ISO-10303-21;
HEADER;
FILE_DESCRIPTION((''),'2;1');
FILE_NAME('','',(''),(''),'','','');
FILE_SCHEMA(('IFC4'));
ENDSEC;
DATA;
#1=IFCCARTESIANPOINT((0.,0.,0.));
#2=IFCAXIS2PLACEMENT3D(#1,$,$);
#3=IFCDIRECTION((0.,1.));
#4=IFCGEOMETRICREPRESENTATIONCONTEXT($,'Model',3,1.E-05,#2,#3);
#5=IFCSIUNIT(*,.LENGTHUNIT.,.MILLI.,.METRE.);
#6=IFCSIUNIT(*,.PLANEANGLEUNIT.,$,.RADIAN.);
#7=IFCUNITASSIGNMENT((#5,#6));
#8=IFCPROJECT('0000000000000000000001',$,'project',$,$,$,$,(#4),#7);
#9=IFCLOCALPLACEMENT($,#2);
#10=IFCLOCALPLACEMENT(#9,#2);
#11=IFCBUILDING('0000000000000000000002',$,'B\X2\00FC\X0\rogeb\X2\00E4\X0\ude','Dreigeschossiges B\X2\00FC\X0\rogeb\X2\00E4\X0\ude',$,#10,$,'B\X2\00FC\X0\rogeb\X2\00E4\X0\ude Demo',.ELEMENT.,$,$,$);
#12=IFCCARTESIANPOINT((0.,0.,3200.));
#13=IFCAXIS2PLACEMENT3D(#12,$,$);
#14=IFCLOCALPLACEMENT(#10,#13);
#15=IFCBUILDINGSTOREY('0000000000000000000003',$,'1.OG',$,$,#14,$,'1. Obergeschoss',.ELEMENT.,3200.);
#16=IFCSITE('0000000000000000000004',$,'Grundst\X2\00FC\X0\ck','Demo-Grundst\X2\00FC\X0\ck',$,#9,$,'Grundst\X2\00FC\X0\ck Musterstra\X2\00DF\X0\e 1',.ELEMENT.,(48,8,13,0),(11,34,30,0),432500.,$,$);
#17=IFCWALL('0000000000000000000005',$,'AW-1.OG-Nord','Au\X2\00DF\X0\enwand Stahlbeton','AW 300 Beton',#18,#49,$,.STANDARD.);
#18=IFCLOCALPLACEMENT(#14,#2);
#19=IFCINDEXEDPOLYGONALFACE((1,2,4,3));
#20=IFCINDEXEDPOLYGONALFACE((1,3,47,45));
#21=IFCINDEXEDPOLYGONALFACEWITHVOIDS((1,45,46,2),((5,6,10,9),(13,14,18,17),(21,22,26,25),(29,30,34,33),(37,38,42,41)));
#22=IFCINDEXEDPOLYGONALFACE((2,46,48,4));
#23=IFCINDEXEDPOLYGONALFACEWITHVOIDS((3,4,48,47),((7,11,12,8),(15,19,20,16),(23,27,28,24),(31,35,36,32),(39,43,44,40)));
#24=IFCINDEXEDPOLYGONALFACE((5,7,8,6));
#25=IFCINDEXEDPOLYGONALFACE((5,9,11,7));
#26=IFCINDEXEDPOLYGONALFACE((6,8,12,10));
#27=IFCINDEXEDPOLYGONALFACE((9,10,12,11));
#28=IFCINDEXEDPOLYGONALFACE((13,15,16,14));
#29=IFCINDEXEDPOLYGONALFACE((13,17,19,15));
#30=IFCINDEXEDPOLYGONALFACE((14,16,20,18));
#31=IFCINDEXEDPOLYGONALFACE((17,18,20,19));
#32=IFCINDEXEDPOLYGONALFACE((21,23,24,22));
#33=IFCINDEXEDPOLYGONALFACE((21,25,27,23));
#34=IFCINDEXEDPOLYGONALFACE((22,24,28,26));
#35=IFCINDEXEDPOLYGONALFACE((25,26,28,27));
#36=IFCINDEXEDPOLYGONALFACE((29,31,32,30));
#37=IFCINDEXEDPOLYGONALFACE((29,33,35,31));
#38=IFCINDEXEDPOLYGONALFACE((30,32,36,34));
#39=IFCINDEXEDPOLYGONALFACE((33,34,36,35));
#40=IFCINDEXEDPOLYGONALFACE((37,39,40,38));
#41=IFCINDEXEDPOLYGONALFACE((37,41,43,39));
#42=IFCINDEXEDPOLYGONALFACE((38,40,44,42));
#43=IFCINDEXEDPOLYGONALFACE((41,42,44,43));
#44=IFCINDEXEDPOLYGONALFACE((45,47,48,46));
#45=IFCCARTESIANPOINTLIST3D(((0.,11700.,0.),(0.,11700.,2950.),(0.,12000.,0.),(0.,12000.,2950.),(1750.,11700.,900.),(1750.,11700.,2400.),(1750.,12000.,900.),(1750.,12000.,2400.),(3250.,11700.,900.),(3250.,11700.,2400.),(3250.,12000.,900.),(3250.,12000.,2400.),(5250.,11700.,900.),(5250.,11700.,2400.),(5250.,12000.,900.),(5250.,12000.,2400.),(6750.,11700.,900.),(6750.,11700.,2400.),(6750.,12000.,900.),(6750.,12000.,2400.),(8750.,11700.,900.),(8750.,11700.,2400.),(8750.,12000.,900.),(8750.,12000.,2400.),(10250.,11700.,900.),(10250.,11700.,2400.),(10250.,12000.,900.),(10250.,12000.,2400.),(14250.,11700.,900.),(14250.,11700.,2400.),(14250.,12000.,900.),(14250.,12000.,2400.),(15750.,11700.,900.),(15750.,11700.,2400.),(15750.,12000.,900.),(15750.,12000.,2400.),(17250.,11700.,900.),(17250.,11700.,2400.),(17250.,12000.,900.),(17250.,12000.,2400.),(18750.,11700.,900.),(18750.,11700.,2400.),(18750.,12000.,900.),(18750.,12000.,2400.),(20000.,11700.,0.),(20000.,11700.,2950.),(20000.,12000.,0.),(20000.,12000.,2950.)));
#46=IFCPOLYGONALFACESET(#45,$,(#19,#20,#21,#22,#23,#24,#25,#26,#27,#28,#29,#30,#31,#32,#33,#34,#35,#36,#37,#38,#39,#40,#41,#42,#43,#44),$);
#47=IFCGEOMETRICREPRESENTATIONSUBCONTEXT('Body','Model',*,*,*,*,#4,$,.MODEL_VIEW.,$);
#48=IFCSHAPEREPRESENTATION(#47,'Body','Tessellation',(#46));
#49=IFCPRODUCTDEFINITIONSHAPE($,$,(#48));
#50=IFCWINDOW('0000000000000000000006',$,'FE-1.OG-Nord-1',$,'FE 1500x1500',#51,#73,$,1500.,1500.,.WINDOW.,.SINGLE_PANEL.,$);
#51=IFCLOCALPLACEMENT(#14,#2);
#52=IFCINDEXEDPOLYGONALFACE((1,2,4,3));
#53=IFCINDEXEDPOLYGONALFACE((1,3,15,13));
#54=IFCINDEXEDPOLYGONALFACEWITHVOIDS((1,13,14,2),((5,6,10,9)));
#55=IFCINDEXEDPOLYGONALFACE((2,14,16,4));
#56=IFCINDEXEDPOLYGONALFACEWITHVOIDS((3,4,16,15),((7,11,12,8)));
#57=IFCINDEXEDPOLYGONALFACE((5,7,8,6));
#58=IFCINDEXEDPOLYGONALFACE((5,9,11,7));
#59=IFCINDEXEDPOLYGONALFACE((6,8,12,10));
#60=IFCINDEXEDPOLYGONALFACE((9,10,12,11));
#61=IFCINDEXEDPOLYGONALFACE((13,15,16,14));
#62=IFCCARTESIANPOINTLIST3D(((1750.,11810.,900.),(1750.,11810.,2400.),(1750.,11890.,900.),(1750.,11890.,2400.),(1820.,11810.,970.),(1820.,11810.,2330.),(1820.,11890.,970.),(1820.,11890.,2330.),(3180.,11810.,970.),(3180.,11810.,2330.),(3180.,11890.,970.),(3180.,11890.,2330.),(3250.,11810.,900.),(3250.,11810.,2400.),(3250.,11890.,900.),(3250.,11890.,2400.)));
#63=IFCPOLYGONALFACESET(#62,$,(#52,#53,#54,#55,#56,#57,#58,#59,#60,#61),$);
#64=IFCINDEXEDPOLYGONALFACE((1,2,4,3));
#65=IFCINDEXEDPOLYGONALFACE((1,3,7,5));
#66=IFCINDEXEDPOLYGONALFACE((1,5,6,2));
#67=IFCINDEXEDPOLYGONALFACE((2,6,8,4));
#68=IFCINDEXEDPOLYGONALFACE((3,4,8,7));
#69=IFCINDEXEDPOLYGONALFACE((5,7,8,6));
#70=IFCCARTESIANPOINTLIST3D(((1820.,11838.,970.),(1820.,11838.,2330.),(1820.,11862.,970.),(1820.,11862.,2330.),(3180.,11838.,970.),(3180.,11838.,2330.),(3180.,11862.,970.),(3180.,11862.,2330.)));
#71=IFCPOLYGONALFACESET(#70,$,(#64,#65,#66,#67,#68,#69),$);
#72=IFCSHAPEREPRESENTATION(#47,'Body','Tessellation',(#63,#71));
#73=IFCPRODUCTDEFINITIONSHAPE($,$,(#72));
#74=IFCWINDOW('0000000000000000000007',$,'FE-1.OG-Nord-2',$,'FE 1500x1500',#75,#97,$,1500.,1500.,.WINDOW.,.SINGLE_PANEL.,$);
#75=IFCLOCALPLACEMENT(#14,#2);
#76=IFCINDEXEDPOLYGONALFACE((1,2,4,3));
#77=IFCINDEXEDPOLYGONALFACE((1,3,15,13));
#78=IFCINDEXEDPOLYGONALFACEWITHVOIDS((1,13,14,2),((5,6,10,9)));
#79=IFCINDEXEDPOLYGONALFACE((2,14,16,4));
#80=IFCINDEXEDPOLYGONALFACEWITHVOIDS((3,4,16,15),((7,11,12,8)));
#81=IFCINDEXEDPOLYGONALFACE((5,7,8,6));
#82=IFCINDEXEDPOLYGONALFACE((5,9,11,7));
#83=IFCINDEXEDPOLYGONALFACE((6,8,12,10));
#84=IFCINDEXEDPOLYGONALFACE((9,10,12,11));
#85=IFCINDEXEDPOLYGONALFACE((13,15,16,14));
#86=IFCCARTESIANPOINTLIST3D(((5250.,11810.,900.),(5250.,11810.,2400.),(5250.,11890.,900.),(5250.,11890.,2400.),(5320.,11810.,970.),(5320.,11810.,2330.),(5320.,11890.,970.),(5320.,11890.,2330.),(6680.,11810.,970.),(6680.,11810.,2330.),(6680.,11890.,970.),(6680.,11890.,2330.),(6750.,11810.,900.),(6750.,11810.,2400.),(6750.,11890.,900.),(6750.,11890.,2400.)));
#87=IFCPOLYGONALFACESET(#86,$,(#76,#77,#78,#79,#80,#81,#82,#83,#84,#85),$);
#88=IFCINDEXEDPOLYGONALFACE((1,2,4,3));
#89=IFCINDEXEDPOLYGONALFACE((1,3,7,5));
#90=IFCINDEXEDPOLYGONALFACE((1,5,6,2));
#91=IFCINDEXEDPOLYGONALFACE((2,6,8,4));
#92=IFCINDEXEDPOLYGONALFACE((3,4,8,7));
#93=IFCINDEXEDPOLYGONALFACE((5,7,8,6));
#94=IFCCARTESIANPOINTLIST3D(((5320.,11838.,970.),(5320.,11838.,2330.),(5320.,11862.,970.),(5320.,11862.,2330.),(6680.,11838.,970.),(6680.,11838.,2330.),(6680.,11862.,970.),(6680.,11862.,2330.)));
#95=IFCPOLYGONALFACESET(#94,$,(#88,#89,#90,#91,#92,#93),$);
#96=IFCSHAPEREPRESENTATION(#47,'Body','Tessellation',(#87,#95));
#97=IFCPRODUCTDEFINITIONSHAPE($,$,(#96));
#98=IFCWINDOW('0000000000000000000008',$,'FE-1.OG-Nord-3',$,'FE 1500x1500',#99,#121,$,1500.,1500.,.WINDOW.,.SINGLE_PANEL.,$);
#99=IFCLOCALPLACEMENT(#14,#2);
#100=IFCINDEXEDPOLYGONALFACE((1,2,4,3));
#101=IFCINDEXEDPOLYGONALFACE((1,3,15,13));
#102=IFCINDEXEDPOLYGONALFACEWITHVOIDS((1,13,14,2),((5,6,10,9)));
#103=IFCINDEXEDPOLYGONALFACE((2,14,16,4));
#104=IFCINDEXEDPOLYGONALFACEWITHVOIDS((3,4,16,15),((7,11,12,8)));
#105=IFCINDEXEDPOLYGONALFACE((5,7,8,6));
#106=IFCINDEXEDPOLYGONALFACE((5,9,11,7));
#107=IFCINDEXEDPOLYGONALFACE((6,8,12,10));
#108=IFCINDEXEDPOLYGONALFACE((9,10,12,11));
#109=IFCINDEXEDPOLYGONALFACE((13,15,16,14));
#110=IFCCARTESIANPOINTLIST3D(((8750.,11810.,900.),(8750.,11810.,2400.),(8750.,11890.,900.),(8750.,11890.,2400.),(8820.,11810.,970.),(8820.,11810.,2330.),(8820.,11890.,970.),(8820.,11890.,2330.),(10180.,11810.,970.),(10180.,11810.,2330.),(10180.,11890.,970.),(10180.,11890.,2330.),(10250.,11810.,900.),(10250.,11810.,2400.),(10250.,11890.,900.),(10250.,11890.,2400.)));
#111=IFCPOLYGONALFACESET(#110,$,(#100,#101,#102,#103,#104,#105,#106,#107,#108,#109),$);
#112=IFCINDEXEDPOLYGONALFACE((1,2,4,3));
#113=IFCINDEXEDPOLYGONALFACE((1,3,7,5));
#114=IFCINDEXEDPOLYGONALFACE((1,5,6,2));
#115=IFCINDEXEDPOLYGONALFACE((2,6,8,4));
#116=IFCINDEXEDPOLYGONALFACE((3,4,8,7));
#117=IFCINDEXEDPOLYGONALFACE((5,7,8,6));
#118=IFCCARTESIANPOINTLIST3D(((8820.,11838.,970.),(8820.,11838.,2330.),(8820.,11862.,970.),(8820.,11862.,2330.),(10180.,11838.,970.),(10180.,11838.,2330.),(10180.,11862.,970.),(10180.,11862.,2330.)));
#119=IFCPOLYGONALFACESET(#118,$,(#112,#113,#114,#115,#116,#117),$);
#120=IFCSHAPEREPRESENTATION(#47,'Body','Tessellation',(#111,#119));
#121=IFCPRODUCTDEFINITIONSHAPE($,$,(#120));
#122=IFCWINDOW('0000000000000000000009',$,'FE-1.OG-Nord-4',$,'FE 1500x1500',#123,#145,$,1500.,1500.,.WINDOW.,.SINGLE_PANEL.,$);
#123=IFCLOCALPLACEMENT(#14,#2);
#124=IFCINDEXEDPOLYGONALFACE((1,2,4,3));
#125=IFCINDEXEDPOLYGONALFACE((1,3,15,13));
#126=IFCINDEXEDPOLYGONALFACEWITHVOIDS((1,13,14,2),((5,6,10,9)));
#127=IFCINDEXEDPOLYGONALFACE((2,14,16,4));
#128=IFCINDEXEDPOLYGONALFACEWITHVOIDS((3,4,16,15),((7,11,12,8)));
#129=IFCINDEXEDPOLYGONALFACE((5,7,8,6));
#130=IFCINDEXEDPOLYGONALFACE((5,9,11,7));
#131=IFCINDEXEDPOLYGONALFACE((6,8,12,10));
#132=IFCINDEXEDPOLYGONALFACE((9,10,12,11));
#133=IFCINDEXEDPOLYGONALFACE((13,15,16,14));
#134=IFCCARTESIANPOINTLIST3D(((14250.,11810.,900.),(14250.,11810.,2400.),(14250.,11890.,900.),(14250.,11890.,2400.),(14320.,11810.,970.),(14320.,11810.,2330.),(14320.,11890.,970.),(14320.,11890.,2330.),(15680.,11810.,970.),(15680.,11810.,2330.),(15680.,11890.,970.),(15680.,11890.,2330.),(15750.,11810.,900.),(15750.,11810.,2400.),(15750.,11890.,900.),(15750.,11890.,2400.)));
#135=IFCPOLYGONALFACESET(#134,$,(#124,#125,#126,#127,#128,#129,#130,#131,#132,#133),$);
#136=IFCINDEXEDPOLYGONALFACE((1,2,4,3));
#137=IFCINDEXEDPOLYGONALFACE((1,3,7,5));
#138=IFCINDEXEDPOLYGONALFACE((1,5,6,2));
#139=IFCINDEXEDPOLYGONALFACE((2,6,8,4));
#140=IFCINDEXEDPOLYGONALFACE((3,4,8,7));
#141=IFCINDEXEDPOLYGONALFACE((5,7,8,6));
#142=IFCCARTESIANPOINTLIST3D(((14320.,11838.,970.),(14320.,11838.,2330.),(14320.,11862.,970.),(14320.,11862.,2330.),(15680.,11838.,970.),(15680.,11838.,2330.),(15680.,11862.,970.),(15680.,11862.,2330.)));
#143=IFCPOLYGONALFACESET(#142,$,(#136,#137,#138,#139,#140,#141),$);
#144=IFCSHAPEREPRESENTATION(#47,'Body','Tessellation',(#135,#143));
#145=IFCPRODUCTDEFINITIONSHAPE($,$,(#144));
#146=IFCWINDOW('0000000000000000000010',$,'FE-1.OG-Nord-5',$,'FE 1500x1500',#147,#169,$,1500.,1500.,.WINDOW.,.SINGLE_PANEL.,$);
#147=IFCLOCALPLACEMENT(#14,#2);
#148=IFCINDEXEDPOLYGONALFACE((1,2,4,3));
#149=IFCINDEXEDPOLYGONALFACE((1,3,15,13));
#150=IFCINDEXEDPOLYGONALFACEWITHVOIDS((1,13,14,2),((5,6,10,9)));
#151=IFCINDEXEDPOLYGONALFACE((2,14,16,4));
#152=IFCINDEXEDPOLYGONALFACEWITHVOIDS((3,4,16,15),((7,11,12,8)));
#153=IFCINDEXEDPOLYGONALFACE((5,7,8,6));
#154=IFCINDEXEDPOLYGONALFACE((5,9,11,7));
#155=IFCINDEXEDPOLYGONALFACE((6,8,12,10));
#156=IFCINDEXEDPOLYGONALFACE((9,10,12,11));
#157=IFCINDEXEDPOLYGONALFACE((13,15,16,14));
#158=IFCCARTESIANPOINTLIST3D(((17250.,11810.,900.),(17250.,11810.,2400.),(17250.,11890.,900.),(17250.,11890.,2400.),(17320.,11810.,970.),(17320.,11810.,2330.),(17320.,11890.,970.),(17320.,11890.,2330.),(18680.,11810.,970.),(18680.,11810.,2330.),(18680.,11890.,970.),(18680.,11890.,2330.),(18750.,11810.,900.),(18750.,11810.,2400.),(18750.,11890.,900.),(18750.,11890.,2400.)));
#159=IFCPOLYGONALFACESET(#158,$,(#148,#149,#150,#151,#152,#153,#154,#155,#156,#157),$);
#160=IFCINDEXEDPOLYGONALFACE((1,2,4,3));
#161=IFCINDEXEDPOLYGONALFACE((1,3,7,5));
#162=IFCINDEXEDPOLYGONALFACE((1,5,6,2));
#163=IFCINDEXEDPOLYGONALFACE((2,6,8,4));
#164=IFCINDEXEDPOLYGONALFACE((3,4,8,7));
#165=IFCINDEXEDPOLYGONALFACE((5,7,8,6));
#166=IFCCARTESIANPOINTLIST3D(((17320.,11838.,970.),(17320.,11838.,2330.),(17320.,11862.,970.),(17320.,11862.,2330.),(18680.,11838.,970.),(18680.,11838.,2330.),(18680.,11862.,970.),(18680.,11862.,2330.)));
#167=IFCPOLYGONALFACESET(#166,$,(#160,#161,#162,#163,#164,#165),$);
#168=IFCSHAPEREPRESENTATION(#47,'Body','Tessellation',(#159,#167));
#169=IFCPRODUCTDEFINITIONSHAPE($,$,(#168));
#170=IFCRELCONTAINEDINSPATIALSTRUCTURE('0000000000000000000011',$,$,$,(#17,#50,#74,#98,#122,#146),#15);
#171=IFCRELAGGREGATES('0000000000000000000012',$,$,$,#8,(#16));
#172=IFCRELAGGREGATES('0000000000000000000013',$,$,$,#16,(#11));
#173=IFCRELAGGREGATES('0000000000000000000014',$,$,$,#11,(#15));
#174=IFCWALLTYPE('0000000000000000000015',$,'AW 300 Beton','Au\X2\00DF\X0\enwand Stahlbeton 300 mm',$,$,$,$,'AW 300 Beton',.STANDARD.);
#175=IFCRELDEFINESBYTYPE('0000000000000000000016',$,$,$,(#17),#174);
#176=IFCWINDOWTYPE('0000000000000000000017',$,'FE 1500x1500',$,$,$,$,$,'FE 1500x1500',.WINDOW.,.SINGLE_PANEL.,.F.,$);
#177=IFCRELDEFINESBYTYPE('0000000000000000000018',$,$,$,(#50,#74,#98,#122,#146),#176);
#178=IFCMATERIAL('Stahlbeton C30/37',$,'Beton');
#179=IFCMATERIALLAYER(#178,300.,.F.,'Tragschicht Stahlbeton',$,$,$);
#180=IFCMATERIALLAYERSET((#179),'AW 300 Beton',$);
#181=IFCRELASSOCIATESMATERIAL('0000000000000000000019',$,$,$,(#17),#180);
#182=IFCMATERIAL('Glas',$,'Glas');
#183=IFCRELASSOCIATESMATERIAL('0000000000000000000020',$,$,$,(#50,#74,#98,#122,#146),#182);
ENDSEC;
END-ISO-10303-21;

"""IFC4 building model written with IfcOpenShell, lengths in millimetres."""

from ifc_helpers import new_model, si_unit, direction, frame, frame_2d, origin, origin_2d, place, context, subcontext, project, spatial, polyline, rectangle, outline, extrude, material, layer, layer_set, layer_usage, type_object, element, fill, save


model = new_model("IFC4")

# Units and contexts
model_context = context("Model", 3, precision=1e-05, world=origin(), true_north=direction((0.0, 1.0)))
body_context = subcontext(model_context, "Body", "Model", "MODEL_VIEW")
ifc_project = project(units=[si_unit("LENGTHUNIT", "METRE", prefix="MILLI"), si_unit("PLANEANGLEUNIT", "RADIAN")], contexts=[model_context])

# Site, building, storey
site_placement = place(None, origin())
site = spatial("IfcSite", under=ifc_project, at=site_placement, Name="Grundstück", Description="Demo-Grundstück", LongName="Grundstück Musterstraße 1", CompositionType="ELEMENT", RefLatitude=(48, 8, 13, 0), RefLongitude=(11, 34, 30, 0), RefElevation=432500.0)
building_placement = place(site_placement, origin())
building = spatial("IfcBuilding", under=site, at=building_placement, Name="Bürogebäude", Description="Dreigeschossiges Bürogebäude", LongName="Bürogebäude Demo", CompositionType="ELEMENT")
storey_placement = place(building_placement, frame((0.0, 0.0, 3200.0)))
storey = spatial("IfcBuildingStorey", under=building, at=storey_placement, Name="1.OG", LongName="1. Obergeschoss", CompositionType="ELEMENT", Elevation=3200.0)

# Shared definitions
ifc_material_1 = material(Name="Stahlbeton C30/37", Category="Beton")

# Wall, openings, windows
ifc_layer_1 = layer(ifc_material_1, 300.0, ventilated=False, Name="Tragschicht Stahlbeton")
ifc_layer_set_1 = layer_set([ifc_layer_1], Name="AW 300 Beton")
ifc_layer_usage_1 = layer_usage(ifc_layer_set_1, "AXIS2", "POSITIVE", -150.0)
wall_type_1 = type_object("IfcWallType", Name="AW 300 Beton", Description="Außenwand Stahlbeton 300 mm", ElementType="AW 300 Beton", PredefinedType="STANDARD")
wall_1_placement = place(storey_placement, frame((0.0, 11850.0, 0.0)))
wall_1 = element("IfcWall", 1, at=wall_1_placement, inside=storey, type_object=wall_type_1, material=ifc_layer_usage_1, Name="AW-1.OG-Nord", Description="Außenwand Stahlbeton", ObjectType="AW 300 Beton", PredefinedType="STANDARD", context=body_context, shape_type="SweptSolid", body=[
    extrude(rectangle(XDim=20000.0, YDim=300.0, at=frame_2d((10000.0, 0.0))), origin(), (0.0, 0.0, 1.0), 2950.0),
])
opening_1_placement = place(wall_1_placement, frame((2500.0, 0.0, 900.0)))
opening_1 = element("IfcOpeningElement", 2, at=opening_1_placement, cuts=wall_1, PredefinedType="OPENING", context=body_context, shape_type="SweptSolid", body=[
    extrude(rectangle(XDim=1500.0, YDim=340.0, at=origin_2d()), origin(), (0.0, 0.0, 1.0), 1500.0),
])
opening_2_placement = place(wall_1_placement, frame((6000.0, 0.0, 900.0)))
opening_2 = element("IfcOpeningElement", 3, at=opening_2_placement, cuts=wall_1, PredefinedType="OPENING", context=body_context, shape_type="SweptSolid", body=[
    extrude(rectangle(XDim=1500.0, YDim=340.0, at=origin_2d()), origin(), (0.0, 0.0, 1.0), 1500.0),
])
opening_3_placement = place(wall_1_placement, frame((9500.0, 0.0, 900.0)))
opening_3 = element("IfcOpeningElement", 4, at=opening_3_placement, cuts=wall_1, PredefinedType="OPENING", context=body_context, shape_type="SweptSolid", body=[
    extrude(rectangle(XDim=1500.0, YDim=340.0, at=origin_2d()), origin(), (0.0, 0.0, 1.0), 1500.0),
])
opening_4_placement = place(wall_1_placement, frame((15000.0, 0.0, 900.0)))
opening_4 = element("IfcOpeningElement", 5, at=opening_4_placement, cuts=wall_1, PredefinedType="OPENING", context=body_context, shape_type="SweptSolid", body=[
    extrude(rectangle(XDim=1500.0, YDim=340.0, at=origin_2d()), origin(), (0.0, 0.0, 1.0), 1500.0),
])
opening_5_placement = place(wall_1_placement, frame((18000.0, 0.0, 900.0)))
opening_5 = element("IfcOpeningElement", 6, at=opening_5_placement, cuts=wall_1, PredefinedType="OPENING", context=body_context, shape_type="SweptSolid", body=[
    extrude(rectangle(XDim=1500.0, YDim=340.0, at=origin_2d()), origin(), (0.0, 0.0, 1.0), 1500.0),
])
ifc_material_2 = material(Name="Glas", Category="Glas")
window_type = type_object("IfcWindowType", Name="FE 1500x1500", ElementType="FE 1500x1500", ParameterTakesPrecedence=False, PartitioningType="SINGLE_PANEL", PredefinedType="WINDOW")
window_1_placement = place(opening_1_placement, origin())
window_1 = element("IfcWindow", 7, at=window_1_placement, inside=storey, type_object=window_type, material=ifc_material_2, Name="FE-1.OG-Nord-1", ObjectType="FE 1500x1500", OverallHeight=1500.0, OverallWidth=1500.0, PartitioningType="SINGLE_PANEL", PredefinedType="WINDOW", context=body_context, shape_type="SweptSolid", body=[
    extrude(outline(polyline([(-750.0, 0.0), (750.0, 0.0), (750.0, 1500.0), (-750.0, 1500.0), (-750.0, 0.0)]), holes=[polyline([(-680.0, 70.0), (680.0, 70.0), (680.0, 1430.0), (-680.0, 1430.0), (-680.0, 70.0)])]), frame((0.0, 40.0, 0.0), z_axis=(0.0, -1.0, 0.0), x_axis=(1.0, 0.0, 0.0)), (0.0, 0.0, 1.0), 80.0),
    extrude(rectangle(XDim=1360.0, YDim=24.0, at=origin_2d()), frame((0.0, 0.0, 70.0)), (0.0, 0.0, 1.0), 1360.0),
])
fill(opening_1, window_1)
window_2_placement = place(opening_2_placement, origin())
window_2 = element("IfcWindow", 8, at=window_2_placement, inside=storey, type_object=window_type, material=ifc_material_2, Name="FE-1.OG-Nord-2", ObjectType="FE 1500x1500", OverallHeight=1500.0, OverallWidth=1500.0, PartitioningType="SINGLE_PANEL", PredefinedType="WINDOW", context=body_context, shape_type="SweptSolid", body=[
    extrude(outline(polyline([(-750.0, 0.0), (750.0, 0.0), (750.0, 1500.0), (-750.0, 1500.0), (-750.0, 0.0)]), holes=[polyline([(-680.0, 70.0), (680.0, 70.0), (680.0, 1430.0), (-680.0, 1430.0), (-680.0, 70.0)])]), frame((0.0, 40.0, 0.0), z_axis=(0.0, -1.0, 0.0), x_axis=(1.0, 0.0, 0.0)), (0.0, 0.0, 1.0), 80.0),
    extrude(rectangle(XDim=1360.0, YDim=24.0, at=origin_2d()), frame((0.0, 0.0, 70.0)), (0.0, 0.0, 1.0), 1360.0),
])
fill(opening_2, window_2)
window_3_placement = place(opening_3_placement, origin())
window_3 = element("IfcWindow", 9, at=window_3_placement, inside=storey, type_object=window_type, material=ifc_material_2, Name="FE-1.OG-Nord-3", ObjectType="FE 1500x1500", OverallHeight=1500.0, OverallWidth=1500.0, PartitioningType="SINGLE_PANEL", PredefinedType="WINDOW", context=body_context, shape_type="SweptSolid", body=[
    extrude(outline(polyline([(-750.0, 0.0), (750.0, 0.0), (750.0, 1500.0), (-750.0, 1500.0), (-750.0, 0.0)]), holes=[polyline([(-680.0, 70.0), (680.0, 70.0), (680.0, 1430.0), (-680.0, 1430.0), (-680.0, 70.0)])]), frame((0.0, 40.0, 0.0), z_axis=(0.0, -1.0, 0.0), x_axis=(1.0, 0.0, 0.0)), (0.0, 0.0, 1.0), 80.0),
    extrude(rectangle(XDim=1360.0, YDim=24.0, at=origin_2d()), frame((0.0, 0.0, 70.0)), (0.0, 0.0, 1.0), 1360.0),
])
fill(opening_3, window_3)
window_4_placement = place(opening_4_placement, origin())
window_4 = element("IfcWindow", 10, at=window_4_placement, inside=storey, type_object=window_type, material=ifc_material_2, Name="FE-1.OG-Nord-4", ObjectType="FE 1500x1500", OverallHeight=1500.0, OverallWidth=1500.0, PartitioningType="SINGLE_PANEL", PredefinedType="WINDOW", context=body_context, shape_type="SweptSolid", body=[
    extrude(outline(polyline([(-750.0, 0.0), (750.0, 0.0), (750.0, 1500.0), (-750.0, 1500.0), (-750.0, 0.0)]), holes=[polyline([(-680.0, 70.0), (680.0, 70.0), (680.0, 1430.0), (-680.0, 1430.0), (-680.0, 70.0)])]), frame((0.0, 40.0, 0.0), z_axis=(0.0, -1.0, 0.0), x_axis=(1.0, 0.0, 0.0)), (0.0, 0.0, 1.0), 80.0),
    extrude(rectangle(XDim=1360.0, YDim=24.0, at=origin_2d()), frame((0.0, 0.0, 70.0)), (0.0, 0.0, 1.0), 1360.0),
])
fill(opening_4, window_4)
window_5_placement = place(opening_5_placement, origin())
window_5 = element("IfcWindow", 11, at=window_5_placement, inside=storey, type_object=window_type, material=ifc_material_2, Name="FE-1.OG-Nord-5", ObjectType="FE 1500x1500", OverallHeight=1500.0, OverallWidth=1500.0, PartitioningType="SINGLE_PANEL", PredefinedType="WINDOW", context=body_context, shape_type="SweptSolid", body=[
    extrude(outline(polyline([(-750.0, 0.0), (750.0, 0.0), (750.0, 1500.0), (-750.0, 1500.0), (-750.0, 0.0)]), holes=[polyline([(-680.0, 70.0), (680.0, 70.0), (680.0, 1430.0), (-680.0, 1430.0), (-680.0, 70.0)])]), frame((0.0, 40.0, 0.0), z_axis=(0.0, -1.0, 0.0), x_axis=(1.0, 0.0, 0.0)), (0.0, 0.0, 1.0), 80.0),
    extrude(rectangle(XDim=1360.0, YDim=24.0, at=origin_2d()), frame((0.0, 0.0, 70.0)), (0.0, 0.0, 1.0), 1360.0),
])
fill(opening_5, window_5)

save(model, "model.ifc")
